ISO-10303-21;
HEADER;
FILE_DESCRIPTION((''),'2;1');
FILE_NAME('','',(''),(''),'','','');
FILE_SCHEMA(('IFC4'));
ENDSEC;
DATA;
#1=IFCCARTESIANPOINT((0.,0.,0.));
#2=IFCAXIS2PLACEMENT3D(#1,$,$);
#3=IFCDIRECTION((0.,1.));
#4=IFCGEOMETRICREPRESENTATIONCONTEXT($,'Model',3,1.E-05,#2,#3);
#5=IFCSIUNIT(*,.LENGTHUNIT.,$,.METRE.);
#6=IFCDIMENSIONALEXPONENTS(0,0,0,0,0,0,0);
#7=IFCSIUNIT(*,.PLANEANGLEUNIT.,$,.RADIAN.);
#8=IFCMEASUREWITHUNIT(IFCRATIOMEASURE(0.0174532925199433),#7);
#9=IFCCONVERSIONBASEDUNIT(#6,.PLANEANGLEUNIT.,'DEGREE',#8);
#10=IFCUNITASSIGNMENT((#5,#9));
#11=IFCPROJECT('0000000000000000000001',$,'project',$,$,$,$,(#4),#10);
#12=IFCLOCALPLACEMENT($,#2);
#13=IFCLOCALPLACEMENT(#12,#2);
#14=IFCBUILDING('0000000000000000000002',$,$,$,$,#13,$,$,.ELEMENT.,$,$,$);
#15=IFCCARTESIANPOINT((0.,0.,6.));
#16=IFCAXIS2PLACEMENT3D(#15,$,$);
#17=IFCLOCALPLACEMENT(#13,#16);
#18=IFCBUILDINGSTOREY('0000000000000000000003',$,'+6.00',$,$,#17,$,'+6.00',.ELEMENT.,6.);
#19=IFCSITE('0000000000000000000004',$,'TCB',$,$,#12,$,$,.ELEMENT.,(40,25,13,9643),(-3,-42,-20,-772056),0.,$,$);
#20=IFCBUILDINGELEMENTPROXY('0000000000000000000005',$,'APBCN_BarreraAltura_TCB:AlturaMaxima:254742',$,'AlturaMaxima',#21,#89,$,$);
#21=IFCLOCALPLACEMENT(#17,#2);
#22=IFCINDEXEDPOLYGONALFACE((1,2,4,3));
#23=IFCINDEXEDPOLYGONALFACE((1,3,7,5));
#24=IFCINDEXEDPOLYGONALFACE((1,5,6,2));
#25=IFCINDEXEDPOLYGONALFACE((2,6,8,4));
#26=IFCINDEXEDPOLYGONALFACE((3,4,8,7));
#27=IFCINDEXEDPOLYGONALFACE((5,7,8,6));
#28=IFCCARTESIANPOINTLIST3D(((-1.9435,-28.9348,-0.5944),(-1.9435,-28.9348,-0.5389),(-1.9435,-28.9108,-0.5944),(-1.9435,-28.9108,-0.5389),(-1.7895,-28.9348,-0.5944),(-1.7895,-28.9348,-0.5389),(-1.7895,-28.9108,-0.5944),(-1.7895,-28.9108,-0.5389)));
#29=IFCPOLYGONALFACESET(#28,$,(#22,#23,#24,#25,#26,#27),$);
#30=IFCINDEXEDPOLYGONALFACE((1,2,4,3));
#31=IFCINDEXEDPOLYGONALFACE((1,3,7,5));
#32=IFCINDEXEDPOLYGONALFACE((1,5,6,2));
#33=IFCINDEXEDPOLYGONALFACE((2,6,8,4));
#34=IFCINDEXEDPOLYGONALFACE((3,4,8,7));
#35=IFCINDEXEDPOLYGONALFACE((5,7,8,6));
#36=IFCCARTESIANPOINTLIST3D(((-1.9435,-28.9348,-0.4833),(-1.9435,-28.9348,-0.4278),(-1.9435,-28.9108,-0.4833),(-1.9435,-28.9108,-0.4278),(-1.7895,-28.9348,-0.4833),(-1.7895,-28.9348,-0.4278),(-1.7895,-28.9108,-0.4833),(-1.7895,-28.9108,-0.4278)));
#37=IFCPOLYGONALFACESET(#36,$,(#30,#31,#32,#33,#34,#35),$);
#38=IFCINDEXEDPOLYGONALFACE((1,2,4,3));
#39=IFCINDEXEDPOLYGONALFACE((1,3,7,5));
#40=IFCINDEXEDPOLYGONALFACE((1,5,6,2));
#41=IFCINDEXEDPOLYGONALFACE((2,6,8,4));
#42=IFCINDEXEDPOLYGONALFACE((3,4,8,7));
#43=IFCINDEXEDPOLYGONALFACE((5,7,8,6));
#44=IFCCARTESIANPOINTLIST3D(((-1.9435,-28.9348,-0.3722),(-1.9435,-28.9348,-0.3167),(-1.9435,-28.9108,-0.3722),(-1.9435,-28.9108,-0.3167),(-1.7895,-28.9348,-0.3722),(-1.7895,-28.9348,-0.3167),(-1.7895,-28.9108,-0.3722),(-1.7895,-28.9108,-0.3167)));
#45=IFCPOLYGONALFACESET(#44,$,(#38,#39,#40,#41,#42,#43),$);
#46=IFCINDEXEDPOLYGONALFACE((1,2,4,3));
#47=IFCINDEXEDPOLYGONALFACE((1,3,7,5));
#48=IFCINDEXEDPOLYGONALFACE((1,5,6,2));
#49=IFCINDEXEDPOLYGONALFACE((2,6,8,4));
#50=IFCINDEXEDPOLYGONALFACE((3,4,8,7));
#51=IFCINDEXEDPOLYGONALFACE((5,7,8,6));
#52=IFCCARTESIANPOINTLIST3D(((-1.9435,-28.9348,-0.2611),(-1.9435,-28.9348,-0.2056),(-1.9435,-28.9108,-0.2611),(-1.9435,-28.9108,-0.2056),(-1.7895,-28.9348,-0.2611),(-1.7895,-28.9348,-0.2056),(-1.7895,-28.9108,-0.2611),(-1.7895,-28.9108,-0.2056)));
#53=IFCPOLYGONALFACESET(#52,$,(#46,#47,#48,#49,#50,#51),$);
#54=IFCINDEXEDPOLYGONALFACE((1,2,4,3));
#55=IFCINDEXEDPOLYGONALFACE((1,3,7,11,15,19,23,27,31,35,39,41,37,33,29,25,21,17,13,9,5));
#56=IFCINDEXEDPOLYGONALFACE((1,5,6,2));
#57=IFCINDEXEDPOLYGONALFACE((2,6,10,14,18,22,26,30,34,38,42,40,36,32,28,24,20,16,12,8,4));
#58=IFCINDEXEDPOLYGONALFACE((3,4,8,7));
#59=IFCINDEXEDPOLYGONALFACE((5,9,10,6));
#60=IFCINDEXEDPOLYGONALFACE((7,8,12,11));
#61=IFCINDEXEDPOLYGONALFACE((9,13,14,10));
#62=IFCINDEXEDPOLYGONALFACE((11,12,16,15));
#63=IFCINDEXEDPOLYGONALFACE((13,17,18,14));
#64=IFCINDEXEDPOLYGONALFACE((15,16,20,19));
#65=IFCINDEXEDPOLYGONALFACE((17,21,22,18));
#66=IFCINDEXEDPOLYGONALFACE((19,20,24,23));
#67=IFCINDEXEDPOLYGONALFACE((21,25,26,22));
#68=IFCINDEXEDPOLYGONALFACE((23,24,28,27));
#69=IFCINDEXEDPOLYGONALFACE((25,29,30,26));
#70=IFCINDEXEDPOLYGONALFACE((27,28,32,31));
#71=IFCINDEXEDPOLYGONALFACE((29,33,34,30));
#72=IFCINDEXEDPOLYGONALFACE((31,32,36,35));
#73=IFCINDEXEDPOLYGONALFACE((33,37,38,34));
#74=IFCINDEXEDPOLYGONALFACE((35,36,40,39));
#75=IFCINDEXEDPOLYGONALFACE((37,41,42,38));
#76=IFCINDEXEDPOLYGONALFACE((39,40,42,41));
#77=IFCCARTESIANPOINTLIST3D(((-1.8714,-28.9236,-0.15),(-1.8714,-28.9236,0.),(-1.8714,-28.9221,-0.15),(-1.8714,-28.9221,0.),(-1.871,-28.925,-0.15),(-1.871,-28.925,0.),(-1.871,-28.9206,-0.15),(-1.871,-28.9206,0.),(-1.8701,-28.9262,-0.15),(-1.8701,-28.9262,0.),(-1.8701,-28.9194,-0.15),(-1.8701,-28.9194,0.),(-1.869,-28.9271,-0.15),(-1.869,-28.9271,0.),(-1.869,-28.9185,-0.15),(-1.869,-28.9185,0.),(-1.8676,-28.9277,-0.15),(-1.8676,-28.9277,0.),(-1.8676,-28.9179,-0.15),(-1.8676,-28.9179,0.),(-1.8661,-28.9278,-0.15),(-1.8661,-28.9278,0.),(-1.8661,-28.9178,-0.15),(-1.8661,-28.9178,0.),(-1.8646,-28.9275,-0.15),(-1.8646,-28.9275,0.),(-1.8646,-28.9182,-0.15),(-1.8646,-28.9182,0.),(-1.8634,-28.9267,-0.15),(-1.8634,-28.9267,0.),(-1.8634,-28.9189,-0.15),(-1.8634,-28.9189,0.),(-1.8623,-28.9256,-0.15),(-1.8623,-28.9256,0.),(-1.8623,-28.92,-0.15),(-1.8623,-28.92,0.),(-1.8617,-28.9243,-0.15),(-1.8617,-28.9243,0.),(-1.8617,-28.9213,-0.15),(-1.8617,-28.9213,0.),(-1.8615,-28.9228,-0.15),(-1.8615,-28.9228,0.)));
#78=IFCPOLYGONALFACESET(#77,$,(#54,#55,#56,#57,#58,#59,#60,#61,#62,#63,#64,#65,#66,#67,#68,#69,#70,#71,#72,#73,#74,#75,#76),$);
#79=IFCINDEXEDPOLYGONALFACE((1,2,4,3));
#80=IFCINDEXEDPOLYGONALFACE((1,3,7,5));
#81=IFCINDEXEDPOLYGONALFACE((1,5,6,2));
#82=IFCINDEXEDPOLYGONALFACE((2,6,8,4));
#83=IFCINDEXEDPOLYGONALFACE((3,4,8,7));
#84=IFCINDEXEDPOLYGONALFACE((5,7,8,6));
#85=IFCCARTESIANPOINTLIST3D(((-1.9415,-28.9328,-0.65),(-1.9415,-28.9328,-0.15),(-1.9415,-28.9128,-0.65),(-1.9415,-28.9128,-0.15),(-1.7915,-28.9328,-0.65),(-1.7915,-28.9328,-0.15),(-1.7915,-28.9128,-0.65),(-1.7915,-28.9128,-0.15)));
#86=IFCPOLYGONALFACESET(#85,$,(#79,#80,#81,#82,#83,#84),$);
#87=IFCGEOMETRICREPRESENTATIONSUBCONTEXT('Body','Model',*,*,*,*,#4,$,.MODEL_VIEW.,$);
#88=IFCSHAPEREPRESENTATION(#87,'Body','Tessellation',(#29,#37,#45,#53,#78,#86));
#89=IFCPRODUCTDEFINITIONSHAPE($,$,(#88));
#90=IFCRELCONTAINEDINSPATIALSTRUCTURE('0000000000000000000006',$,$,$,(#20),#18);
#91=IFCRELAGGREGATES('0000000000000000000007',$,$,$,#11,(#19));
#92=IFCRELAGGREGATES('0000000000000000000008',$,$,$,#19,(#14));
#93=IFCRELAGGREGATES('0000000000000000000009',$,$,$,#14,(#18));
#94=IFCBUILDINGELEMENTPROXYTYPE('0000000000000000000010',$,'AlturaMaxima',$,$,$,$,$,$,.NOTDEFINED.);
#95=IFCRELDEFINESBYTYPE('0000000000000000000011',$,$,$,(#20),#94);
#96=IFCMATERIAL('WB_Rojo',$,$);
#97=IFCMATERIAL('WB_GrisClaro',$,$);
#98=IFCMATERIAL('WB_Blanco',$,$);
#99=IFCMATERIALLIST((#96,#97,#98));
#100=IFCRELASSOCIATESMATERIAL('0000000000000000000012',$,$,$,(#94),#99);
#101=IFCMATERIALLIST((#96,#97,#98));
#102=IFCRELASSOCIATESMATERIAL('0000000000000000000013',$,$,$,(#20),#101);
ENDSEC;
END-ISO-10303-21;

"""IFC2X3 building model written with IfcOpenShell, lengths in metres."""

from ifc_helpers import new_model, entity, si_unit, converted_unit, direction, frame, frame_2d, origin, origin_2d_with_axis, place, context, subcontext, project, spatial, rectangle, circle, extrude, source, transform, mapped, material, material_list, type_object, type_shapes, element, save


model = new_model("IFC2X3")

# Units and contexts
model_context = context("Model", 3, precision=1e-05, world=origin(), true_north=direction((0.0, 1.0)))
body_context = subcontext(model_context, "Body", "Model", "MODEL_VIEW")
ifc_project = project(units=[si_unit("LENGTHUNIT", "METRE"), converted_unit("PLANEANGLEUNIT", "DEGREE", entity("IfcRatioMeasure", 0.0174532925199433), si_unit("PLANEANGLEUNIT", "RADIAN"), dimensions=[0, 0, 0, 0, 0, 0, 0])], contexts=[model_context])

# Site, building, storey
site_placement = place(None, origin())
site = spatial("IfcSite", under=ifc_project, at=site_placement, Name="TCB", CompositionType="ELEMENT", RefLatitude=(40, 25, 13, 9643), RefLongitude=(-3, -42, -20, -772056), RefElevation=0.0)
building_placement = place(site_placement, origin())
building = spatial("IfcBuilding", under=site, at=building_placement, CompositionType="ELEMENT")
storey_placement = place(building_placement, frame((0.0, 0.0, 6.0)))
storey = spatial("IfcBuildingStorey", under=building, at=storey_placement, Name="+6.00", LongName="+6.00", CompositionType="ELEMENT", Elevation=6.0)

# Building element proxy
ifc_material_1 = material(Name="WB_Rojo")
ifc_material_2 = material(Name="WB_GrisClaro")
ifc_material_3 = material(Name="WB_Blanco")
ifc_material_list_1 = material_list([ifc_material_1, ifc_material_2, ifc_material_3])
building_element_proxy_type = type_object("IfcBuildingElementProxyType", Name="AlturaMaxima", PredefinedType="NOTDEFINED", material=ifc_material_list_1)
shared_shape = source(origin(), body_context, "Body", "SweptSolid", [
    extrude(rectangle(XDim=0.154, YDim=0.024, at=frame_2d((0.0, 0.0), x_axis=(1.0, 0.0))), frame((0.0, 0.0, -0.5944), z_axis=(0.0, 0.0, 1.0), x_axis=(-1.0, 0.0, 0.0)), (0.0, 0.0, 1.0), 0.0556),
    extrude(rectangle(XDim=0.154, YDim=0.024, at=frame_2d((0.0, 0.0), x_axis=(1.0, 0.0))), frame((0.0, 0.0, -0.4833), z_axis=(0.0, 0.0, 1.0), x_axis=(-1.0, 0.0, 0.0)), (0.0, 0.0, 1.0), 0.0556),
    extrude(rectangle(XDim=0.154, YDim=0.024, at=frame_2d((0.0, 0.0), x_axis=(1.0, 0.0))), frame((0.0, 0.0, -0.3722), z_axis=(0.0, 0.0, 1.0), x_axis=(-1.0, 0.0, 0.0)), (0.0, 0.0, 1.0), 0.0556),
    extrude(rectangle(XDim=0.154, YDim=0.024, at=frame_2d((0.0, 0.0), x_axis=(1.0, 0.0))), frame((0.0, 0.0, -0.2611), z_axis=(0.0, 0.0, 1.0), x_axis=(-1.0, 0.0, 0.0)), (0.0, 0.0, 1.0), 0.0556),
    extrude(circle(Radius=0.005, at=frame_2d((0.0, 0.0), x_axis=(1.0, 0.0))), frame((0.0, 0.0, -0.15)), (0.0, 0.0, 1.0), 0.15),
    extrude(rectangle(XDim=0.02, YDim=0.15, at=origin_2d_with_axis()), frame((0.0, 0.0, -0.65), z_axis=(0.0, 0.0, 1.0), x_axis=(0.0, 1.0, 0.0)), (0.0, 0.0, 1.0), 0.5),
])
type_shapes(building_element_proxy_type, [shared_shape])
ifc_material_list_2 = material_list([ifc_material_1, ifc_material_2, ifc_material_3])
proxy_1_placement = place(storey_placement, frame((-1.8665, -28.9228, 0.0)))
element("IfcBuildingElementProxy", 1, at=proxy_1_placement, inside=storey, type_object=building_element_proxy_type, material=ifc_material_list_2, Name="APBCN_BarreraAltura_TCB:AlturaMaxima:254742", ObjectType="AlturaMaxima", context=body_context, shape_type="MappedRepresentation", body=[
    mapped(shared_shape, transform((0.0, 0.0, 0.0), scale=1.0)),
])

save(model, "model.ifc")
